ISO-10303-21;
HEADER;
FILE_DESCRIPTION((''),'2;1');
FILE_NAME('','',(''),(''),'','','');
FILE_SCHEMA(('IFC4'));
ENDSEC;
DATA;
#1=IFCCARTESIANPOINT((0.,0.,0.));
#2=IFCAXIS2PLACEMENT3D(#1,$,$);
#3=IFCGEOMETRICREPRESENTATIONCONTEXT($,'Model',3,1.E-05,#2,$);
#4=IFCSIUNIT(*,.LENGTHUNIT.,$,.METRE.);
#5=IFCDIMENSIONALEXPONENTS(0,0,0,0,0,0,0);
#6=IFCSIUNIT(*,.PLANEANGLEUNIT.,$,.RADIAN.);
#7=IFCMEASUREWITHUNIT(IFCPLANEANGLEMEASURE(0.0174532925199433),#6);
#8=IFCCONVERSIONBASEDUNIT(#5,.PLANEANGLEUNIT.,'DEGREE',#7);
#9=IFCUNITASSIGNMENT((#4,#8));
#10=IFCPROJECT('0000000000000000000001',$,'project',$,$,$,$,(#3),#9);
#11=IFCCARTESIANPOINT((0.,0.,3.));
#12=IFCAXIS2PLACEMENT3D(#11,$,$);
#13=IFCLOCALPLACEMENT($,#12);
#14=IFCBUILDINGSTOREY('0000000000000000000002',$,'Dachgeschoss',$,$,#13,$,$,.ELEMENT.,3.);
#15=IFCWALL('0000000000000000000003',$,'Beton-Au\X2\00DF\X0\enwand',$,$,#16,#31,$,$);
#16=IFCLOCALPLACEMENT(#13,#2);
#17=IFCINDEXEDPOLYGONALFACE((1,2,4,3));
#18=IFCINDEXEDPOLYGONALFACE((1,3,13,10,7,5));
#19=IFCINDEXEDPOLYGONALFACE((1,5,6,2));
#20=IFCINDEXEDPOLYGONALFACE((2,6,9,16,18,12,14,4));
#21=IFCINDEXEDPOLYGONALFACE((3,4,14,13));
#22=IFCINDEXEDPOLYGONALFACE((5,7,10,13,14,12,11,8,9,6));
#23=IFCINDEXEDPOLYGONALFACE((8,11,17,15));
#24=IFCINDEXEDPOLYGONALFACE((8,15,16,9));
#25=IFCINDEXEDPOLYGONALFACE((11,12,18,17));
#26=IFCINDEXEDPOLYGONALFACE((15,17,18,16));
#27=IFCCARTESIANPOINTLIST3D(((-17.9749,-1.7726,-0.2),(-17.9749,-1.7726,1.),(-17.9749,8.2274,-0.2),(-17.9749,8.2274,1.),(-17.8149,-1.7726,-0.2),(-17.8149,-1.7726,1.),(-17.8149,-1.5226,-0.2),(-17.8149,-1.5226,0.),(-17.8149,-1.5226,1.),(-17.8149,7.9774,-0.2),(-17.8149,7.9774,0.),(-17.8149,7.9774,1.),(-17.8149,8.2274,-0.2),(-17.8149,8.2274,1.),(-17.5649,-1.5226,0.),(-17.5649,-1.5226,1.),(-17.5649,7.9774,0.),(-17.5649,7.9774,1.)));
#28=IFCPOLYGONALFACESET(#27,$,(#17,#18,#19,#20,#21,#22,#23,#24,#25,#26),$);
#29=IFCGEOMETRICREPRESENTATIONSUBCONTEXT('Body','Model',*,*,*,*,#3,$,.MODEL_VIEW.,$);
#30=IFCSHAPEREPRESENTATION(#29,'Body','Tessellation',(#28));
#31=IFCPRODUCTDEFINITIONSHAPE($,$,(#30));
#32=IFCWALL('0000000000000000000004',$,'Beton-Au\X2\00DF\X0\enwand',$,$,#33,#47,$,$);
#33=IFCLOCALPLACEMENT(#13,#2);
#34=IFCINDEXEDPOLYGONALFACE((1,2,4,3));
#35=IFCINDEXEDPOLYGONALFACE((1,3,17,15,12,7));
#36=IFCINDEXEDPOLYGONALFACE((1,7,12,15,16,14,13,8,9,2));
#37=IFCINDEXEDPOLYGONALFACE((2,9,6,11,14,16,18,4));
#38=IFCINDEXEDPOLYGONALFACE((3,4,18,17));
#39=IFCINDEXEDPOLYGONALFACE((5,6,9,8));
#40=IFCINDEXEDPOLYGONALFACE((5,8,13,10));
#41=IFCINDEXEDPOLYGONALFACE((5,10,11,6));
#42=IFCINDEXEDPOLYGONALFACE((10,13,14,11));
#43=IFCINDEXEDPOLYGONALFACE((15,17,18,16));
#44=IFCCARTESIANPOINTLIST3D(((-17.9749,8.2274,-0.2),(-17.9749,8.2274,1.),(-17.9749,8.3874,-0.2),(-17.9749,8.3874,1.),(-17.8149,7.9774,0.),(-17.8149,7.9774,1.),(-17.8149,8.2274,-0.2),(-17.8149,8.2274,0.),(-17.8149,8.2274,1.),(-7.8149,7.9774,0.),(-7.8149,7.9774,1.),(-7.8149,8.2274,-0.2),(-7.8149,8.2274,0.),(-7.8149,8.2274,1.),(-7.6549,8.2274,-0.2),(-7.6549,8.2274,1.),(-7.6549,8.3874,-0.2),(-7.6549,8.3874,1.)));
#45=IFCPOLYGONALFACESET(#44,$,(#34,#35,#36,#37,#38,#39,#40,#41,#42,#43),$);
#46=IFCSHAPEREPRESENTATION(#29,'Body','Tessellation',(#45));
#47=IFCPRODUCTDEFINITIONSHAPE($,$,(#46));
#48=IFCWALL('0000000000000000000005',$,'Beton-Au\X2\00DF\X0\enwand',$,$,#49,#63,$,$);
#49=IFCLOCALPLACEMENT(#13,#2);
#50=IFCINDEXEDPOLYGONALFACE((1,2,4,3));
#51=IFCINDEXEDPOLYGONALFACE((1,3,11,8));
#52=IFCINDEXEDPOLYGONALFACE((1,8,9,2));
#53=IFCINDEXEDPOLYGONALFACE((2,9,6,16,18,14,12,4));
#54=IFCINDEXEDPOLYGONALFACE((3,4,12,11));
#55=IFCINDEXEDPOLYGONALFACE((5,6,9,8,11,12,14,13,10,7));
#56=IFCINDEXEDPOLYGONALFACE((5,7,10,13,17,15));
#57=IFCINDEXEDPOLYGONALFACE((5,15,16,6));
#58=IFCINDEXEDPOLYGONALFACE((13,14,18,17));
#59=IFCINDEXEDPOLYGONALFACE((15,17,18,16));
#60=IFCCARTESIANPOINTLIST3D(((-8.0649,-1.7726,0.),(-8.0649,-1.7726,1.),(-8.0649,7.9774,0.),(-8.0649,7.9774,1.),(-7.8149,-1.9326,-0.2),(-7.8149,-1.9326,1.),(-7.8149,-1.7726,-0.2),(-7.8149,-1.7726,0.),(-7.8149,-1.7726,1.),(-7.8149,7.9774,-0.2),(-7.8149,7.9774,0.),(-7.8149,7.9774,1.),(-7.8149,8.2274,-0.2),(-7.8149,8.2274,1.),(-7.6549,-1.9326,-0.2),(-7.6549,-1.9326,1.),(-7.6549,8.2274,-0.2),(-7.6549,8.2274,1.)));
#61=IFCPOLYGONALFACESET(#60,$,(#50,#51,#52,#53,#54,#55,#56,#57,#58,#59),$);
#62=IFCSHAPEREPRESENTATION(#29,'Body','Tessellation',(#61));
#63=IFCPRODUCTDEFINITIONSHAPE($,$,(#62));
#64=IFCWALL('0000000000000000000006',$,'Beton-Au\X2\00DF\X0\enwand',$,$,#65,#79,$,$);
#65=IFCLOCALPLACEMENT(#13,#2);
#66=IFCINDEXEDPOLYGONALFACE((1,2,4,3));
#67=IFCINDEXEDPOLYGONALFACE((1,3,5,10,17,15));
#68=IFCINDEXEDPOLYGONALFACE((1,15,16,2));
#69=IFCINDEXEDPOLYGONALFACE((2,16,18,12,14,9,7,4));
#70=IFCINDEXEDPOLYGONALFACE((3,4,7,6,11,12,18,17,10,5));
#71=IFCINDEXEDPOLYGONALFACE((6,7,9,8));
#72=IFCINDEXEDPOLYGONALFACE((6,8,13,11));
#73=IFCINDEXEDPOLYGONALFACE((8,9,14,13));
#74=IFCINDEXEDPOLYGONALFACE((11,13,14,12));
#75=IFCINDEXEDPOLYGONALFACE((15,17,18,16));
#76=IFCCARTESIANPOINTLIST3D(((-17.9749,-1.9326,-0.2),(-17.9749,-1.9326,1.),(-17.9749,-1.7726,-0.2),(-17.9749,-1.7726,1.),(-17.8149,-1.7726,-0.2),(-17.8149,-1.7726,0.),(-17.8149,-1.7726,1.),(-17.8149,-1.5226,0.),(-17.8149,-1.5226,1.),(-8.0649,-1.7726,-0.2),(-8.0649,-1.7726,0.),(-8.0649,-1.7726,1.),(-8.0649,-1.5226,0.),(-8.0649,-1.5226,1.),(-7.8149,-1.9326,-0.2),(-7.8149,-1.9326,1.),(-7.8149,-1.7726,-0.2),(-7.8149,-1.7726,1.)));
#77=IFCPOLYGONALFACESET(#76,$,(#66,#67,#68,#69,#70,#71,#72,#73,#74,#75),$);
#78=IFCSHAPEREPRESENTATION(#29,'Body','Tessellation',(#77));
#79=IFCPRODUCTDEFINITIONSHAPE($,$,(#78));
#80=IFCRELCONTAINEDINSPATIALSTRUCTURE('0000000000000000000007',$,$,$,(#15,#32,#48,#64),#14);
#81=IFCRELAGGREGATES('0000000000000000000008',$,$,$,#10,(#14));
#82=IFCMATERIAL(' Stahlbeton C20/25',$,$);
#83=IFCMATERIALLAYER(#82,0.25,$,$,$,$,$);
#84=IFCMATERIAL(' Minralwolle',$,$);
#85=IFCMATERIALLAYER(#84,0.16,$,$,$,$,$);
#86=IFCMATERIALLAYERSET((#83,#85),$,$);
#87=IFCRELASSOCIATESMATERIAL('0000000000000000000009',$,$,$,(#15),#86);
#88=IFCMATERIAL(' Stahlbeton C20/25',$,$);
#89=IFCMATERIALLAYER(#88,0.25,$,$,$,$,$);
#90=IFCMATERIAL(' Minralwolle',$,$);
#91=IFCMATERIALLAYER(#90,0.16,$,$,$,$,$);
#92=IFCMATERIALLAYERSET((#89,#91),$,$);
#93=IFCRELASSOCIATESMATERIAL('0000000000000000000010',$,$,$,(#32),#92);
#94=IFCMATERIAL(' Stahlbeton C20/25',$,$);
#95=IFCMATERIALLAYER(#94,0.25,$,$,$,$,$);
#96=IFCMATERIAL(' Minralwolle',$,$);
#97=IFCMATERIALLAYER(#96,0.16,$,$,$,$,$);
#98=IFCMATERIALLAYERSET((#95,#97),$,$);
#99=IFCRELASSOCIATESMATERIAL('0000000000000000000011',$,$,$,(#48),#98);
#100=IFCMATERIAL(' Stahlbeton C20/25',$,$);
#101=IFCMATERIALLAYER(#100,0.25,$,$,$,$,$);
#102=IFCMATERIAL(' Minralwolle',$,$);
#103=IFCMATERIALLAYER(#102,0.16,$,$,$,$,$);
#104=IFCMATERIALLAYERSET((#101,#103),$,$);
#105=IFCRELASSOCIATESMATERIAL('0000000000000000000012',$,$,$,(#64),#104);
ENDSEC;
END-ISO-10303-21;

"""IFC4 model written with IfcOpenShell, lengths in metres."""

from ifc_helpers import new_model, entity, si_unit, converted_unit, frame, origin, origin_with_axes, place, context, subcontext, project, spatial, polyline, outline, extrude, clip, bounded_halfspace, material, layer, layer_set, layer_usage, element, save


model = new_model("IFC4")

# Units and contexts
model_context = context("Model", 3, precision=1e-05, world=origin())
body_context = subcontext(model_context, "Body", "Model", "MODEL_VIEW")
ifc_project = project(units=[si_unit("LENGTHUNIT", "METRE"), converted_unit("PLANEANGLEUNIT", "DEGREE", entity("IfcPlaneAngleMeasure", 0.0174532925199433), si_unit("PLANEANGLEUNIT", "RADIAN"), dimensions=[0, 0, 0, 0, 0, 0, 0])], contexts=[model_context])

# Storey
storey_placement = place(None, frame((0.0, 0.0, 3.0)))
storey = spatial("IfcBuildingStorey", under=ifc_project, at=storey_placement, Name="Dachgeschoss", CompositionType="ELEMENT", Elevation=3.0)

# Walls
ifc_material_1 = material(Name=" Stahlbeton C20/25")
ifc_layer_1 = layer(ifc_material_1, 0.25)
ifc_material_2 = material(Name=" Minralwolle")
ifc_layer_2 = layer(ifc_material_2, 0.16)
ifc_layer_set_1 = layer_set([ifc_layer_1, ifc_layer_2])
ifc_layer_usage_1 = layer_usage(ifc_layer_set_1, "AXIS2", "POSITIVE", -0.25)
wall_1_placement = place(storey_placement, frame((-17.5649, -1.5226, -0.2), z_axis=(0.0, 0.0, 1.0), x_axis=(0.0, 1.0, 0.0)))
element("IfcWall", 1, at=wall_1_placement, inside=storey, material=ifc_layer_usage_1, Name="Beton-Außenwand", context=body_context, shape_type="Clipping", body=[
    clip(extrude(outline(polyline([(0.25, -0.41), (9.75, -0.41), (9.75, -0.16), (10.0, -0.16), (10.0, 0.0), (0.0, 0.0), (0.0, -0.16), (0.25, -0.16), (0.25, -0.41)])), frame((-0.25, 0.41, 0.0), z_axis=(0.0, 0.0, 1.0), x_axis=(1.0, 0.0, 0.0)), (0.0, 0.0, 1.0), 1.2), bounded_halfspace(frame((4.75, 0.125, 0.2), z_axis=(0.0, 0.0, 1.0), x_axis=(0.0, -1.0, 0.0)), True, origin_with_axes(), polyline([(0.0, 0.25), (0.0, 0.0), (9.5, 0.0), (9.5, 0.25), (0.0, 0.25)]))),
])
ifc_material_3 = material(Name=" Stahlbeton C20/25")
ifc_layer_3 = layer(ifc_material_3, 0.25)
ifc_material_4 = material(Name=" Minralwolle")
ifc_layer_4 = layer(ifc_material_4, 0.16)
ifc_layer_set_2 = layer_set([ifc_layer_3, ifc_layer_4])
ifc_layer_usage_2 = layer_usage(ifc_layer_set_2, "AXIS2", "POSITIVE", -0.25)
wall_2_placement = place(storey_placement, frame((-17.8149, 7.9774, -0.2)))
element("IfcWall", 2, at=wall_2_placement, inside=storey, material=ifc_layer_usage_2, Name="Beton-Außenwand", context=body_context, shape_type="Clipping", body=[
    clip(extrude(outline(polyline([(0.16, 0.0), (10.16, 0.0), (10.16, 0.25), (10.32, 0.25), (10.32, 0.41), (0.0, 0.41), (0.0, 0.25), (0.16, 0.25), (0.16, 0.0)])), frame((-0.16, 0.0, 0.0), z_axis=(0.0, 0.0, 1.0), x_axis=(1.0, 0.0, 0.0)), (0.0, 0.0, 1.0), 1.2), bounded_halfspace(frame((5.0, 0.125, 0.2), z_axis=(0.0, 0.0, 1.0), x_axis=(0.0, -1.0, 0.0)), True, origin_with_axes(), polyline([(0.0, 0.25), (0.0, 0.0), (10.0, 0.0), (10.0, 0.25), (0.0, 0.25)]))),
])
ifc_material_5 = material(Name=" Stahlbeton C20/25")
ifc_layer_5 = layer(ifc_material_5, 0.25)
ifc_material_6 = material(Name=" Minralwolle")
ifc_layer_6 = layer(ifc_material_6, 0.16)
ifc_layer_set_3 = layer_set([ifc_layer_5, ifc_layer_6])
ifc_layer_usage_3 = layer_usage(ifc_layer_set_3, "AXIS2", "POSITIVE", -0.25)
wall_3_placement = place(storey_placement, frame((-8.0649, 7.9774, -0.2), z_axis=(0.0, 0.0, 1.0), x_axis=(0.0, -1.0, 0.0)))
element("IfcWall", 3, at=wall_3_placement, inside=storey, material=ifc_layer_usage_3, Name="Beton-Außenwand", context=body_context, shape_type="Clipping", body=[
    clip(extrude(outline(polyline([(-9.91, 0.0), (-0.16, 0.0), (-0.16, 0.25), (0.0, 0.25), (0.0, 0.41), (-10.16, 0.41), (-10.16, 0.25), (-9.91, 0.25), (-9.91, 0.0)])), frame((9.91, 0.0, 0.0), z_axis=(0.0, 0.0, 1.0), x_axis=(1.0, 0.0, 0.0)), (0.0, 0.0, 1.0), 1.2), bounded_halfspace(frame((4.875, 0.125, 0.2), z_axis=(0.0, 0.0, 1.0), x_axis=(0.0, -1.0, 0.0)), True, origin_with_axes(), polyline([(0.0, 0.25), (0.0, 0.0), (9.75, 0.0), (9.75, 0.25), (0.0, 0.25)]))),
])
ifc_material_7 = material(Name=" Stahlbeton C20/25")
ifc_layer_7 = layer(ifc_material_7, 0.25)
ifc_material_8 = material(Name=" Minralwolle")
ifc_layer_8 = layer(ifc_material_8, 0.16)
ifc_layer_set_4 = layer_set([ifc_layer_7, ifc_layer_8])
ifc_layer_usage_4 = layer_usage(ifc_layer_set_4, "AXIS2", "POSITIVE", -0.25)
wall_4_placement = place(storey_placement, frame((-8.0649, -1.5226, -0.2), z_axis=(0.0, 0.0, 1.0), x_axis=(-1.0, 0.0, 0.0)))
element("IfcWall", 4, at=wall_4_placement, inside=storey, material=ifc_layer_usage_4, Name="Beton-Außenwand", context=body_context, shape_type="Clipping", body=[
    clip(extrude(outline(polyline([(-9.91, -0.41), (-0.16, -0.41), (-0.16, -0.16), (0.0, -0.16), (0.0, 0.0), (-10.16, 0.0), (-10.16, -0.16), (-9.91, -0.16), (-9.91, -0.41)])), frame((9.91, 0.41, 0.0), z_axis=(0.0, 0.0, 1.0), x_axis=(1.0, 0.0, 0.0)), (0.0, 0.0, 1.0), 1.2), bounded_halfspace(frame((4.875, 0.125, 0.2), z_axis=(0.0, 0.0, 1.0), x_axis=(0.0, -1.0, 0.0)), True, origin_with_axes(), polyline([(0.0, 0.25), (0.0, 0.0), (9.75, 0.0), (9.75, 0.25), (0.0, 0.25)]))),
])

save(model, "model.ifc")
